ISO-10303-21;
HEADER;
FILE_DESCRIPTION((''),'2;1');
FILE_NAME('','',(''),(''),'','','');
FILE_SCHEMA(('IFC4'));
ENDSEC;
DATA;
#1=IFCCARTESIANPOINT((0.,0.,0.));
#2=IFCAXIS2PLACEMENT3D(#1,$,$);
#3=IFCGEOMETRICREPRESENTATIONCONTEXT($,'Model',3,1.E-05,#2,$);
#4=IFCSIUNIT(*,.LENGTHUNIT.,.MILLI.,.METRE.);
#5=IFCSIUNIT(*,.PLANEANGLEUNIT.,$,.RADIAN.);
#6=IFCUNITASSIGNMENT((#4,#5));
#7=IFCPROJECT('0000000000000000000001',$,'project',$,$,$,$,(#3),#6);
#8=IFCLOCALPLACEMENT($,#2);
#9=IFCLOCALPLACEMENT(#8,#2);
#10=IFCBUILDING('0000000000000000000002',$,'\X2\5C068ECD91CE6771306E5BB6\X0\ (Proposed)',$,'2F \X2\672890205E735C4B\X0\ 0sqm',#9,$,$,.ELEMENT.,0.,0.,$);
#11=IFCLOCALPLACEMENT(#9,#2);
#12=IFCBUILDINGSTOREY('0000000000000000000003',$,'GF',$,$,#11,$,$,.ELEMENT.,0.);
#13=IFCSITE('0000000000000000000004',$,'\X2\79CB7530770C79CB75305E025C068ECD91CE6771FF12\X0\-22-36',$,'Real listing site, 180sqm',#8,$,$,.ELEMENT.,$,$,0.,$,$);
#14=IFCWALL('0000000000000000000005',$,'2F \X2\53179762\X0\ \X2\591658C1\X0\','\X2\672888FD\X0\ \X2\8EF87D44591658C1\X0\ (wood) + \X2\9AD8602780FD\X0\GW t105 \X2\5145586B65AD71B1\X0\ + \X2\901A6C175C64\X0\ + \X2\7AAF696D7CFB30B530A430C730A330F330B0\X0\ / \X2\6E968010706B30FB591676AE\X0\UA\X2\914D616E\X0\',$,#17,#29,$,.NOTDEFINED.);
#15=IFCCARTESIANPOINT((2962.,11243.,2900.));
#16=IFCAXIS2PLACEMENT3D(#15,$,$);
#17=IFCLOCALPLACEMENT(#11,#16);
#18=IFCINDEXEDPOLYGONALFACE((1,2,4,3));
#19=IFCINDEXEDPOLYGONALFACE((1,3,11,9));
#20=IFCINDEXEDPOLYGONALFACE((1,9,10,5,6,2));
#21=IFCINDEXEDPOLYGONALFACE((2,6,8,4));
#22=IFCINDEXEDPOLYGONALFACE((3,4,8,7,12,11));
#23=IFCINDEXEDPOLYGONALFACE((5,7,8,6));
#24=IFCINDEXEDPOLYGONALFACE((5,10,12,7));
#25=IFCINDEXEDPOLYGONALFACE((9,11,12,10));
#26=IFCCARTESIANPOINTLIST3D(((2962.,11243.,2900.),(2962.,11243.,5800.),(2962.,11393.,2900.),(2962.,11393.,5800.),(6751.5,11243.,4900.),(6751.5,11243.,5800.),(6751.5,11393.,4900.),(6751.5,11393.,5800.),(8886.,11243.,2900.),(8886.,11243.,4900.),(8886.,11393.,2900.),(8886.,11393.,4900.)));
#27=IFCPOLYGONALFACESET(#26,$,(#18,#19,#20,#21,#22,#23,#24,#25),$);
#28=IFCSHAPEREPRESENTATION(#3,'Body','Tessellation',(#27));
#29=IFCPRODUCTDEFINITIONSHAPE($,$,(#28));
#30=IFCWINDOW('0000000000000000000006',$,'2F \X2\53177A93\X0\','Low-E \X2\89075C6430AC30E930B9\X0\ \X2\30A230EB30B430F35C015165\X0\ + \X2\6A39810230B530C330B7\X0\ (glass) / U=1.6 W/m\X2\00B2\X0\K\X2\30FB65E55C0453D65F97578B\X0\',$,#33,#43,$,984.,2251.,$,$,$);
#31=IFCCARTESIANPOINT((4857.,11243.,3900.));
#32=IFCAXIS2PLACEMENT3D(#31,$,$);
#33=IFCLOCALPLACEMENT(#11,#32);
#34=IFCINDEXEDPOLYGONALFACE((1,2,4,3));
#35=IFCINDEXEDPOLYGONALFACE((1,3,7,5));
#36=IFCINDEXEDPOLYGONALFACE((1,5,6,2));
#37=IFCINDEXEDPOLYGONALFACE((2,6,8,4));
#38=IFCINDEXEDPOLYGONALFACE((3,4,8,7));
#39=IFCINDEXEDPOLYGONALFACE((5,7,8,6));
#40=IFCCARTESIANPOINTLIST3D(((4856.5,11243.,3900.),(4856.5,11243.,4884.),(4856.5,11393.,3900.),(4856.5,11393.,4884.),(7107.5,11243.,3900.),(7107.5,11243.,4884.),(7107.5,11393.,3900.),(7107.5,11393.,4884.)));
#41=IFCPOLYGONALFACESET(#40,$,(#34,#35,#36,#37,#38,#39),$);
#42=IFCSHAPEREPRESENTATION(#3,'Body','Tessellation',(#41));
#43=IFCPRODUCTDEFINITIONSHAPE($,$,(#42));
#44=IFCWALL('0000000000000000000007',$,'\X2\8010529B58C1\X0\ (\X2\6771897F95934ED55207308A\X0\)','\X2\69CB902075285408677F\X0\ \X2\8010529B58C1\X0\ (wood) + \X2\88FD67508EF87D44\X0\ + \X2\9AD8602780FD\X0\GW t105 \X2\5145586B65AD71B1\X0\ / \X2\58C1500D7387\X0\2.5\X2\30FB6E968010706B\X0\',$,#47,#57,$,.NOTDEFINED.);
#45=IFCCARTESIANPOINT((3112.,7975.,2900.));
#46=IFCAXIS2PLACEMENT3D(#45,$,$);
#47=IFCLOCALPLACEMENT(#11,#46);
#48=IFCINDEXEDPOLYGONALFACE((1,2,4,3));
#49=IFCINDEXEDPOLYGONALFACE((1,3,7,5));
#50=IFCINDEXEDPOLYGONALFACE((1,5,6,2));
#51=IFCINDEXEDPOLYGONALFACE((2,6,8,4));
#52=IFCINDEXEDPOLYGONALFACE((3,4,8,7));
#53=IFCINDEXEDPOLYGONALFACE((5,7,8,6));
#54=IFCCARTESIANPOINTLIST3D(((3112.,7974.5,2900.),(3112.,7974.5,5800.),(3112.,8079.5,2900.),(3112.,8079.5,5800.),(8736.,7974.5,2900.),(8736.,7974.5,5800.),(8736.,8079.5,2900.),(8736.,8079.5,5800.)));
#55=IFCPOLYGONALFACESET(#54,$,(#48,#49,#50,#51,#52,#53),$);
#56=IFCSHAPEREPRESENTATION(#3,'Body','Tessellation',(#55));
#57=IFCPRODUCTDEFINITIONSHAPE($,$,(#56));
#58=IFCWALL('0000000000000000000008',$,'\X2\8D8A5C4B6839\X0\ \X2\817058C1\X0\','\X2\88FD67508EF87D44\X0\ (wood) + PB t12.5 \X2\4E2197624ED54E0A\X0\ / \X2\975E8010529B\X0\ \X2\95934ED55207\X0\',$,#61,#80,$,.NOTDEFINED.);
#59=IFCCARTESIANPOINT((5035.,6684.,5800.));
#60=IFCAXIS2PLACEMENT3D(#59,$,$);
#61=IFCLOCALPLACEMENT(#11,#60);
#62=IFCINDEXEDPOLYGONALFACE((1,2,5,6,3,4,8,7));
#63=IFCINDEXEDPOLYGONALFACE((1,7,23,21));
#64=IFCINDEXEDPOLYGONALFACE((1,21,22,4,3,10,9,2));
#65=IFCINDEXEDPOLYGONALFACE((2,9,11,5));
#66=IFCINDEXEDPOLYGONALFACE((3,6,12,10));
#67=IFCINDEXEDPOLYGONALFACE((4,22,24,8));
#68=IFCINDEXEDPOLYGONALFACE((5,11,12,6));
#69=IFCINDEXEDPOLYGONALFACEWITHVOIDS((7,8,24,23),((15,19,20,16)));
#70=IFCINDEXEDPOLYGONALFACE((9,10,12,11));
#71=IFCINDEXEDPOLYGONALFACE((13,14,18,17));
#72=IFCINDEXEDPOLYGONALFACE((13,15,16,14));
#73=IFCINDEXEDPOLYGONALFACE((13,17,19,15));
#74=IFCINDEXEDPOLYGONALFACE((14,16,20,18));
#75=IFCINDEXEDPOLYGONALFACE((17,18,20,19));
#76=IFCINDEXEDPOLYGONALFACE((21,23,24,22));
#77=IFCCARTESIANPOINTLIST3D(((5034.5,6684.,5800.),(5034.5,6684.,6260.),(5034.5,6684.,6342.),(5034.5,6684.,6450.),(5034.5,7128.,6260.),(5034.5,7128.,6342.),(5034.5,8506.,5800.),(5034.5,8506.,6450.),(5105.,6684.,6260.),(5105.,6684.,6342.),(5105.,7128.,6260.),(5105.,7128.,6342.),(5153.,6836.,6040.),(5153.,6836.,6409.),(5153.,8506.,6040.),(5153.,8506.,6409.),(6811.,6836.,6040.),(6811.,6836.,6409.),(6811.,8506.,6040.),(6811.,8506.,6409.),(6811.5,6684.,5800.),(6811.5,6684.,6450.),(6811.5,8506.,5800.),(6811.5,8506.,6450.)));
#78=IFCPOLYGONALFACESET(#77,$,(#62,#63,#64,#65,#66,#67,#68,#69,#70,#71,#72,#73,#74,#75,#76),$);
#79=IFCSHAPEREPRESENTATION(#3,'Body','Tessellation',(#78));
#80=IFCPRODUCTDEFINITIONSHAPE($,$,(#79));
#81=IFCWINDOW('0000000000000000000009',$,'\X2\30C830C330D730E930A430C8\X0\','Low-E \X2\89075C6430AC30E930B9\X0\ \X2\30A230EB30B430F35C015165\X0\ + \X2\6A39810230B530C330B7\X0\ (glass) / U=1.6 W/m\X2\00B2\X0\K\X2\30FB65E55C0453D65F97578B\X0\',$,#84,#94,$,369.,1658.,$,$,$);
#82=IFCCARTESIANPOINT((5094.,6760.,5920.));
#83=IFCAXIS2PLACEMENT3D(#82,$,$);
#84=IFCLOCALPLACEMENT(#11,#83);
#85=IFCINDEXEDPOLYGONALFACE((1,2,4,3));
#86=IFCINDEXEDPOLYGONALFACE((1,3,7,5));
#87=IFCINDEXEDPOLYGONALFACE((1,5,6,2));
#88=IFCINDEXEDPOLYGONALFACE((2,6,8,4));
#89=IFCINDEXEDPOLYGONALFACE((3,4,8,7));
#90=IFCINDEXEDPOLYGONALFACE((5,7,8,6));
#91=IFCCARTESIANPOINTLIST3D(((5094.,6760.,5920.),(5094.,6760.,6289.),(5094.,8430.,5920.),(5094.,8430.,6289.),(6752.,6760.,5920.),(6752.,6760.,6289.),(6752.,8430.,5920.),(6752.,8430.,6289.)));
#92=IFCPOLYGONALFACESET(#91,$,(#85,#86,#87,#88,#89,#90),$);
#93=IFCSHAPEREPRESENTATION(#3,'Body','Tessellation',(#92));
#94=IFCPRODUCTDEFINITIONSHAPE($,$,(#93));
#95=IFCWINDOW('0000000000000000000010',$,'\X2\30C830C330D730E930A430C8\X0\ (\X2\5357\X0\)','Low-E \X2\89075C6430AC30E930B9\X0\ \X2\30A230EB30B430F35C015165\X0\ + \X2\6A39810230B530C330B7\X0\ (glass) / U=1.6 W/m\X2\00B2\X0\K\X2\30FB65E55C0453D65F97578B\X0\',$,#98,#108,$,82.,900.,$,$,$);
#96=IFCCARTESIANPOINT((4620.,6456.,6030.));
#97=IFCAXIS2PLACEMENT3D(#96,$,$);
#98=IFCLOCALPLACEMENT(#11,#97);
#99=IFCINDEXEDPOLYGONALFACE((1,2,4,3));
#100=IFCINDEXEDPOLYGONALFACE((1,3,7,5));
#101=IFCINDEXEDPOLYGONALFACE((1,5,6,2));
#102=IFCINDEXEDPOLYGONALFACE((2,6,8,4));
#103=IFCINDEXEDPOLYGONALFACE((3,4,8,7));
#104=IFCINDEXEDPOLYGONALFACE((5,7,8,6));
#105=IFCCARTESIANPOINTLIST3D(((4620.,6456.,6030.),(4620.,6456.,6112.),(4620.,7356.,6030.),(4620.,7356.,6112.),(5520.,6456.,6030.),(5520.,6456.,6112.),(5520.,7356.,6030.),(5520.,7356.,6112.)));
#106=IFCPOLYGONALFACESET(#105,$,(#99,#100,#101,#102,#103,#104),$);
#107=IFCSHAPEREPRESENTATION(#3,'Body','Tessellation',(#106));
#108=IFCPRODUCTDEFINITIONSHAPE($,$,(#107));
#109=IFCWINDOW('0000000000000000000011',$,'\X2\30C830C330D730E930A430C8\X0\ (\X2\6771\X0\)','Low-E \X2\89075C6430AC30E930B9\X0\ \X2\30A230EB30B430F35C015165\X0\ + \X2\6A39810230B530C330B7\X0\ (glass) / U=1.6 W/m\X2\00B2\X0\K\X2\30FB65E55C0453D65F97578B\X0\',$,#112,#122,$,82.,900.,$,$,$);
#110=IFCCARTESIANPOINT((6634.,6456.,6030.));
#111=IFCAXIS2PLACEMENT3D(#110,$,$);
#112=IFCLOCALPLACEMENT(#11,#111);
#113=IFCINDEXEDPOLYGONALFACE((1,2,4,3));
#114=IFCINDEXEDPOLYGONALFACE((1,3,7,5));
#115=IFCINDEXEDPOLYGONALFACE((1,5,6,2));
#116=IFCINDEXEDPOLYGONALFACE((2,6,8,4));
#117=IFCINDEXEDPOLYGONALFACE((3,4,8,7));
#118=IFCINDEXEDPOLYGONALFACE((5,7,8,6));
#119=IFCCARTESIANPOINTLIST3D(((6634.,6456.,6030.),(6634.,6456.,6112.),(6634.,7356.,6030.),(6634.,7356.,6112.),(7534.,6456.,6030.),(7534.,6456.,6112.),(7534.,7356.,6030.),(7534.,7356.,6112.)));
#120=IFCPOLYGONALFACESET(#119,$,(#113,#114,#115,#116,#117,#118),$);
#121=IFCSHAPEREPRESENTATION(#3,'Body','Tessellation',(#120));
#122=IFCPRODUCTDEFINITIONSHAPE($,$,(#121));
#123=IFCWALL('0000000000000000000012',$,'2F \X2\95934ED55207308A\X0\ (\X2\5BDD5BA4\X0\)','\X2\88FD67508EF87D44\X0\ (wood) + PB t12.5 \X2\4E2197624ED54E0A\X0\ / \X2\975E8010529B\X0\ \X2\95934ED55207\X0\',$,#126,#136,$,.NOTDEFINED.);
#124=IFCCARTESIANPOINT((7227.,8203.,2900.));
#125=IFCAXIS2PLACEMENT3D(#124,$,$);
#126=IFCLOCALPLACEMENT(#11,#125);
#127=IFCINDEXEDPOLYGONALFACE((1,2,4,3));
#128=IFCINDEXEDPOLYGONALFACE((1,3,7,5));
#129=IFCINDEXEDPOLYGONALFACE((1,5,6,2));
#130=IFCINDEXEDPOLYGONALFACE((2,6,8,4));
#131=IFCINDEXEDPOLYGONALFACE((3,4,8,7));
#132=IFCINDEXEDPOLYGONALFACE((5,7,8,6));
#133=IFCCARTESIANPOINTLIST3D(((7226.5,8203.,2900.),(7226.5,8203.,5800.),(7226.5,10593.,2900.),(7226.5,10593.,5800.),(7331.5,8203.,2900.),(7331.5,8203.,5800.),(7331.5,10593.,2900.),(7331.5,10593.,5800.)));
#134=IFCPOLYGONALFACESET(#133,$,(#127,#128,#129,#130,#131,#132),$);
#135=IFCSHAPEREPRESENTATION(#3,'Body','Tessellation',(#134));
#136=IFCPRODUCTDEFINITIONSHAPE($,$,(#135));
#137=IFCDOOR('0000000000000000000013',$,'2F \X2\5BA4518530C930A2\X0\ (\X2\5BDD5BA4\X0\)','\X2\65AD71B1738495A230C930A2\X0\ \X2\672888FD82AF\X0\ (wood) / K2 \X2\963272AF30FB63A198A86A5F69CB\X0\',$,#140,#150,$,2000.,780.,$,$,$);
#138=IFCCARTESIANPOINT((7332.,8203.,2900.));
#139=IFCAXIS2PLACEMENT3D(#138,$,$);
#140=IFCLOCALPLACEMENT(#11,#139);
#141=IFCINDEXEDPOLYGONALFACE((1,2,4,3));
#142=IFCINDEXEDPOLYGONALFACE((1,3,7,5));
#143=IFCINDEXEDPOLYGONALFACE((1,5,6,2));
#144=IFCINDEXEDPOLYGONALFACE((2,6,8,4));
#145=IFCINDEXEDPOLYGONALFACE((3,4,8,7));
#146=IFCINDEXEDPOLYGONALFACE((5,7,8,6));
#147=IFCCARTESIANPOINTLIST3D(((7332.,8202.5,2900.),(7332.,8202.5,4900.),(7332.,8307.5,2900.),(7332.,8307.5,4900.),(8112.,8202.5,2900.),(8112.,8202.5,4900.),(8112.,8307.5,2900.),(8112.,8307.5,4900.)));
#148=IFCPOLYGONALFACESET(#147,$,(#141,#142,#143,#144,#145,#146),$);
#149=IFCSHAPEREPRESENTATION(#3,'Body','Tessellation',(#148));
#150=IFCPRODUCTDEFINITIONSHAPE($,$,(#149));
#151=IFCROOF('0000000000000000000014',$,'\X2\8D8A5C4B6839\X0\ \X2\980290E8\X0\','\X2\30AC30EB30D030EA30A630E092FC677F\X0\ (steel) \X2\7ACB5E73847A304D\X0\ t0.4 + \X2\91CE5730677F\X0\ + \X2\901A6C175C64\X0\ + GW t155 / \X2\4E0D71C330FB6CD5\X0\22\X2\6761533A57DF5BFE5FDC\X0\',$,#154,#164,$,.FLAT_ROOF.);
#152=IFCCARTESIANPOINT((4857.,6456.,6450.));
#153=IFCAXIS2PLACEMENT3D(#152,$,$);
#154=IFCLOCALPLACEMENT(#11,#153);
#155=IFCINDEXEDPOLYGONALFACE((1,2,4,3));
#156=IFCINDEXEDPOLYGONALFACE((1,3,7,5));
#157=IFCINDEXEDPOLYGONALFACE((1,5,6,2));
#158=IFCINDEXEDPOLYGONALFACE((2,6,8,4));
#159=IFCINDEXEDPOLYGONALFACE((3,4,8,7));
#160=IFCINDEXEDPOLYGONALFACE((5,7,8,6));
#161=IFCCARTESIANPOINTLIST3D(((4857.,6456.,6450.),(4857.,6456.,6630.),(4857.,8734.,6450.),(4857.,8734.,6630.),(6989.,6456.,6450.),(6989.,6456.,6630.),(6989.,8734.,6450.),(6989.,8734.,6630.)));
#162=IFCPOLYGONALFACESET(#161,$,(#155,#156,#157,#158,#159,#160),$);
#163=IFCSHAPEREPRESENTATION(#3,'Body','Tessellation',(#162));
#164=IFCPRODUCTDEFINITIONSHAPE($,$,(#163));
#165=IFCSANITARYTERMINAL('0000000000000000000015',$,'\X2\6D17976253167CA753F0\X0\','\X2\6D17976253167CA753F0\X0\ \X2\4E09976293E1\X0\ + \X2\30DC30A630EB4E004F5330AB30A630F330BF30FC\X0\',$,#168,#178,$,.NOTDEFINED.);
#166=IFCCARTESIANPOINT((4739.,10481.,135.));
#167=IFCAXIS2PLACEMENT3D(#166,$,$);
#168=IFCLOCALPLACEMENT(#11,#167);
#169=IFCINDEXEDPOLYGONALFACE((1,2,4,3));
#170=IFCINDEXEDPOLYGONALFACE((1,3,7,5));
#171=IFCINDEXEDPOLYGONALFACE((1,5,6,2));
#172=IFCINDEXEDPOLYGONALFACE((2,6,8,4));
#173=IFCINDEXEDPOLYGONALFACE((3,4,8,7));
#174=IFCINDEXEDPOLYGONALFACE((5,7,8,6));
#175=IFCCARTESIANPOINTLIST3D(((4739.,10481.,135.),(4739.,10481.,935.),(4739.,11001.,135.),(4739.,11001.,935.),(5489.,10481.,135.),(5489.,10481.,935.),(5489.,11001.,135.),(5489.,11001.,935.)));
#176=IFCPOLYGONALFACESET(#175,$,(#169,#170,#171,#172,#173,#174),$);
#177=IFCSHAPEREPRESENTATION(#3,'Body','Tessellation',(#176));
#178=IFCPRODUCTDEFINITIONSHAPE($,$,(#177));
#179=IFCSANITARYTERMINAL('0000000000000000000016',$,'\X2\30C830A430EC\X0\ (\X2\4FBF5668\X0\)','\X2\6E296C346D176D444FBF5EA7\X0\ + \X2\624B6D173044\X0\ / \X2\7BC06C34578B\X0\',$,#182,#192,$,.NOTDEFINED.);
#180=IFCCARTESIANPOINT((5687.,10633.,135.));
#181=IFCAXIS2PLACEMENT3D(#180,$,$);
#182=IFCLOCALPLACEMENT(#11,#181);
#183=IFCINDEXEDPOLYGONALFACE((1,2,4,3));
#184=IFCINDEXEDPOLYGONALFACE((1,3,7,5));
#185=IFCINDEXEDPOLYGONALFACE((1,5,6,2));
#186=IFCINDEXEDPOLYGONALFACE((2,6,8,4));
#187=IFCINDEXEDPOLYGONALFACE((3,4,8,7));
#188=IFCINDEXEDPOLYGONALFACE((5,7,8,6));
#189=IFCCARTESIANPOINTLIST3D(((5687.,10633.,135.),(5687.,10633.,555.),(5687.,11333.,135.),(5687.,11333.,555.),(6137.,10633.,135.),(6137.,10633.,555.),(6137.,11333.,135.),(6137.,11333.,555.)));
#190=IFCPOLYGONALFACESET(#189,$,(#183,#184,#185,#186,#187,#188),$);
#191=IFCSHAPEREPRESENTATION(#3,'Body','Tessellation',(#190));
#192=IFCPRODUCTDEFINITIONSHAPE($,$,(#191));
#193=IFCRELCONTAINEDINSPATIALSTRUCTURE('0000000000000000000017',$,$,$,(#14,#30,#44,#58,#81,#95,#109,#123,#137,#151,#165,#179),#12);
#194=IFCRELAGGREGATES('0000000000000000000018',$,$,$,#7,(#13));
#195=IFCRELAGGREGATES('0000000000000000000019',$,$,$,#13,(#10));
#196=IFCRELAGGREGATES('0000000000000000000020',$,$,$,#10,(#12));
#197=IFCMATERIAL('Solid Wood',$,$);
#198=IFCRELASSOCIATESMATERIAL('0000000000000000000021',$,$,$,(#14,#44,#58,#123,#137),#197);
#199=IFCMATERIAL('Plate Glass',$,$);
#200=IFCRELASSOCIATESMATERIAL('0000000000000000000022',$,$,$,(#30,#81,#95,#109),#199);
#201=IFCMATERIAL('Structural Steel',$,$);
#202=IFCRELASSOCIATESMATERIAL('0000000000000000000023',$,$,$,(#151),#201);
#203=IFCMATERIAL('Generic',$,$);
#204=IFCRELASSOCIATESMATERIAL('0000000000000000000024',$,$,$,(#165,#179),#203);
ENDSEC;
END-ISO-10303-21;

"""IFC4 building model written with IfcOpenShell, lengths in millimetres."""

from ifc_helpers import new_model, si_unit, frame, frame_2d, origin, place, context, project, spatial, rectangle, extrude, material, element, fill, save


model = new_model("IFC4")

# Units and contexts
model_context = context("Model", 3, precision=1e-05, world=origin())
ifc_project = project(units=[si_unit("LENGTHUNIT", "METRE", prefix="MILLI"), si_unit("PLANEANGLEUNIT", "RADIAN")], contexts=[model_context])

# Site, building, storey
site_placement = place(None, origin())
site = spatial("IfcSite", under=ifc_project, at=site_placement, Name="秋田県秋田市将軍野東２-22-36", ObjectType="Real listing site, 180sqm", CompositionType="ELEMENT", RefElevation=0.0)
building_placement = place(site_placement, origin())
building = spatial("IfcBuilding", under=site, at=building_placement, Name="将軍野東の家 (Proposed)", ObjectType="2F 木造平屋 0sqm", CompositionType="ELEMENT", ElevationOfRefHeight=0.0, ElevationOfTerrain=0.0)
storey_placement = place(building_placement, origin())
storey = spatial("IfcBuildingStorey", under=building, at=storey_placement, Name="GF", CompositionType="ELEMENT", Elevation=0.0)

# Wall, opening, window
ifc_material_1 = material(Name="Solid Wood")
wall_1_placement = place(storey_placement, frame((2962.0, 11243.0, 2900.0)))
wall_1 = element("IfcWall", 1, at=wall_1_placement, inside=storey, material=ifc_material_1, Name="2F 北面 外壁", Description="木製 軸組外壁 (wood) + 高性能GW t105 充填断熱 + 通気層 + 窯業系サイディング / 準耐火・外皮UA配慮", PredefinedType="NOTDEFINED", context=model_context, shape_type="SweptSolid", body=[
    extrude(rectangle(XDim=5924.0, YDim=150.0, at=frame_2d((2962.0, 75.0))), frame((2962.0, 11243.0, 2900.0)), (0.0, 0.0, 1.0), 2900.0),
])
opening_1_placement = place(storey_placement, frame((4857.0, 11243.0, 3900.0)))
opening_1 = element("IfcOpeningElement", 2, at=opening_1_placement, cuts=wall_1, PredefinedType="NOTDEFINED", context=model_context, shape_type="SweptSolid", body=[
    extrude(rectangle(XDim=2251.0, YDim=150.0, at=frame_2d((1125.0, 75.0))), frame((4857.0, 11243.0, 3900.0)), (0.0, 0.0, 1.0), 984.0),
])
ifc_material_2 = material(Name="Plate Glass")
window_1_placement = place(storey_placement, frame((4857.0, 11243.0, 3900.0)))
window_1 = element("IfcWindow", 3, at=window_1_placement, inside=storey, material=ifc_material_2, Name="2F 北窓", Description="Low-E 複層ガラス アルゴン封入 + 樹脂サッシ (glass) / U=1.6 W/m²K・日射取得型", OverallHeight=984.0, OverallWidth=2251.0, context=model_context, shape_type="SweptSolid", body=[
    extrude(rectangle(XDim=2251.0, YDim=150.0, at=frame_2d((1125.0, 75.0))), frame((4857.0, 11243.0, 3900.0)), (0.0, 0.0, 1.0), 984.0),
])
fill(opening_1, window_1)

# Wall
wall_2_placement = place(storey_placement, frame((3112.0, 7975.0, 2900.0)))
element("IfcWall", 4, at=wall_2_placement, inside=storey, material=ifc_material_1, Name="耐力壁 (東西間仕切り)", Description="構造用合板 耐力壁 (wood) + 製材軸組 + 高性能GW t105 充填断熱 / 壁倍率2.5・準耐火", PredefinedType="NOTDEFINED", context=model_context, shape_type="SweptSolid", body=[
    extrude(rectangle(XDim=5624.0, YDim=105.0, at=frame_2d((2812.0, 52.0))), frame((3112.0, 7975.0, 2900.0)), (0.0, 0.0, 1.0), 2900.0),
])

# Wall, openings, windows
wall_3_placement = place(storey_placement, frame((5035.0, 6684.0, 5800.0)))
wall_3 = element("IfcWall", 5, at=wall_3_placement, inside=storey, material=ifc_material_1, Name="越屋根 腰壁", Description="製材軸組 (wood) + PB t12.5 両面仕上 / 非耐力 間仕切", PredefinedType="NOTDEFINED", context=model_context, shape_type="SweptSolid", body=[
    extrude(rectangle(XDim=1777.0, YDim=1822.0, at=frame_2d((888.0, 911.0))), frame((5035.0, 6684.0, 5800.0)), (0.0, 0.0, 1.0), 650.0),
])
opening_2_placement = place(storey_placement, frame((5094.0, 6760.0, 5920.0)))
opening_2 = element("IfcOpeningElement", 6, at=opening_2_placement, cuts=wall_3, PredefinedType="NOTDEFINED", context=model_context, shape_type="SweptSolid", body=[
    extrude(rectangle(XDim=1658.0, YDim=1670.0, at=frame_2d((829.0, 835.0))), frame((5094.0, 6760.0, 5920.0)), (0.0, 0.0, 1.0), 369.0),
])
opening_3_placement = place(storey_placement, frame((4620.0, 6456.0, 6030.0)))
opening_3 = element("IfcOpeningElement", 7, at=opening_3_placement, cuts=wall_3, PredefinedType="NOTDEFINED", context=model_context, shape_type="SweptSolid", body=[
    extrude(rectangle(XDim=900.0, YDim=900.0, at=frame_2d((450.0, 450.0))), frame((4620.0, 6456.0, 6030.0)), (0.0, 0.0, 1.0), 82.0),
])
opening_4_placement = place(storey_placement, frame((6634.0, 6456.0, 6030.0)))
opening_4 = element("IfcOpeningElement", 8, at=opening_4_placement, cuts=wall_3, PredefinedType="NOTDEFINED", context=model_context, shape_type="SweptSolid", body=[
    extrude(rectangle(XDim=900.0, YDim=900.0, at=frame_2d((450.0, 450.0))), frame((6634.0, 6456.0, 6030.0)), (0.0, 0.0, 1.0), 82.0),
])
window_2_placement = place(storey_placement, frame((5094.0, 6760.0, 5920.0)))
window_2 = element("IfcWindow", 9, at=window_2_placement, inside=storey, material=ifc_material_2, Name="トップライト", Description="Low-E 複層ガラス アルゴン封入 + 樹脂サッシ (glass) / U=1.6 W/m²K・日射取得型", OverallHeight=369.0, OverallWidth=1658.0, context=model_context, shape_type="SweptSolid", body=[
    extrude(rectangle(XDim=1658.0, YDim=1670.0, at=frame_2d((829.0, 835.0))), frame((5094.0, 6760.0, 5920.0)), (0.0, 0.0, 1.0), 369.0),
])
fill(opening_2, window_2)
window_3_placement = place(storey_placement, frame((4620.0, 6456.0, 6030.0)))
window_3 = element("IfcWindow", 10, at=window_3_placement, inside=storey, material=ifc_material_2, Name="トップライト (南)", Description="Low-E 複層ガラス アルゴン封入 + 樹脂サッシ (glass) / U=1.6 W/m²K・日射取得型", OverallHeight=82.0, OverallWidth=900.0, context=model_context, shape_type="SweptSolid", body=[
    extrude(rectangle(XDim=900.0, YDim=900.0, at=frame_2d((450.0, 450.0))), frame((4620.0, 6456.0, 6030.0)), (0.0, 0.0, 1.0), 82.0),
])
fill(opening_3, window_3)
window_4_placement = place(storey_placement, frame((6634.0, 6456.0, 6030.0)))
window_4 = element("IfcWindow", 11, at=window_4_placement, inside=storey, material=ifc_material_2, Name="トップライト (東)", Description="Low-E 複層ガラス アルゴン封入 + 樹脂サッシ (glass) / U=1.6 W/m²K・日射取得型", OverallHeight=82.0, OverallWidth=900.0, context=model_context, shape_type="SweptSolid", body=[
    extrude(rectangle(XDim=900.0, YDim=900.0, at=frame_2d((450.0, 450.0))), frame((6634.0, 6456.0, 6030.0)), (0.0, 0.0, 1.0), 82.0),
])
fill(opening_4, window_4)

# Wall
wall_4_placement = place(storey_placement, frame((7227.0, 8203.0, 2900.0)))
element("IfcWall", 12, at=wall_4_placement, inside=storey, material=ifc_material_1, Name="2F 間仕切り (寝室)", Description="製材軸組 (wood) + PB t12.5 両面仕上 / 非耐力 間仕切", PredefinedType="NOTDEFINED", context=model_context, shape_type="SweptSolid", body=[
    extrude(rectangle(XDim=105.0, YDim=2390.0, at=frame_2d((52.0, 1195.0))), frame((7227.0, 8203.0, 2900.0)), (0.0, 0.0, 1.0), 2900.0),
])

# Door
door_placement = place(storey_placement, frame((7332.0, 8203.0, 2900.0)))
element("IfcDoor", 13, at=door_placement, inside=storey, material=ifc_material_1, Name="2F 室内ドア (寝室)", Description="断熱玄関ドア 木製芯 (wood) / K2 防犯・採風機構", OverallHeight=2000.0, OverallWidth=780.0, context=model_context, shape_type="SweptSolid", body=[
    extrude(rectangle(XDim=780.0, YDim=105.0, at=frame_2d((390.0, 52.0))), frame((7332.0, 8203.0, 2900.0)), (0.0, 0.0, 1.0), 2000.0),
])

# Roof
ifc_material_3 = material(Name="Structural Steel")
roof_placement = place(storey_placement, frame((4857.0, 6456.0, 6450.0)))
element("IfcRoof", 14, at=roof_placement, inside=storey, material=ifc_material_3, Name="越屋根 頂部", Description="ガルバリウム鋼板 (steel) 立平葺き t0.4 + 野地板 + 通気層 + GW t155 / 不燃・法22条区域対応", PredefinedType="FLAT_ROOF", context=model_context, shape_type="SweptSolid", body=[
    extrude(rectangle(XDim=2132.0, YDim=2278.0, at=frame_2d((1066.0, 1139.0))), frame((4857.0, 6456.0, 6450.0)), (0.0, 0.0, 1.0), 180.0),
])

# Sanitary terminals
ifc_material_4 = material(Name="Generic")
sanitary_terminal_1_placement = place(storey_placement, frame((4739.0, 10481.0, 135.0)))
element("IfcSanitaryTerminal", 15, at=sanitary_terminal_1_placement, inside=storey, material=ifc_material_4, Name="洗面化粧台", Description="洗面化粧台 三面鏡 + ボウル一体カウンター", PredefinedType="NOTDEFINED", context=model_context, shape_type="SweptSolid", body=[
    extrude(rectangle(XDim=750.0, YDim=520.0, at=frame_2d((375.0, 260.0))), frame((4739.0, 10481.0, 135.0)), (0.0, 0.0, 1.0), 800.0),
])
sanitary_terminal_2_placement = place(storey_placement, frame((5687.0, 10633.0, 135.0)))
element("IfcSanitaryTerminal", 16, at=sanitary_terminal_2_placement, inside=storey, material=ifc_material_4, Name="トイレ (便器)", Description="温水洗浄便座 + 手洗い / 節水型", PredefinedType="NOTDEFINED", context=model_context, shape_type="SweptSolid", body=[
    extrude(rectangle(XDim=450.0, YDim=700.0, at=frame_2d((225.0, 350.0))), frame((5687.0, 10633.0, 135.0)), (0.0, 0.0, 1.0), 420.0),
])

save(model, "model.ifc")
